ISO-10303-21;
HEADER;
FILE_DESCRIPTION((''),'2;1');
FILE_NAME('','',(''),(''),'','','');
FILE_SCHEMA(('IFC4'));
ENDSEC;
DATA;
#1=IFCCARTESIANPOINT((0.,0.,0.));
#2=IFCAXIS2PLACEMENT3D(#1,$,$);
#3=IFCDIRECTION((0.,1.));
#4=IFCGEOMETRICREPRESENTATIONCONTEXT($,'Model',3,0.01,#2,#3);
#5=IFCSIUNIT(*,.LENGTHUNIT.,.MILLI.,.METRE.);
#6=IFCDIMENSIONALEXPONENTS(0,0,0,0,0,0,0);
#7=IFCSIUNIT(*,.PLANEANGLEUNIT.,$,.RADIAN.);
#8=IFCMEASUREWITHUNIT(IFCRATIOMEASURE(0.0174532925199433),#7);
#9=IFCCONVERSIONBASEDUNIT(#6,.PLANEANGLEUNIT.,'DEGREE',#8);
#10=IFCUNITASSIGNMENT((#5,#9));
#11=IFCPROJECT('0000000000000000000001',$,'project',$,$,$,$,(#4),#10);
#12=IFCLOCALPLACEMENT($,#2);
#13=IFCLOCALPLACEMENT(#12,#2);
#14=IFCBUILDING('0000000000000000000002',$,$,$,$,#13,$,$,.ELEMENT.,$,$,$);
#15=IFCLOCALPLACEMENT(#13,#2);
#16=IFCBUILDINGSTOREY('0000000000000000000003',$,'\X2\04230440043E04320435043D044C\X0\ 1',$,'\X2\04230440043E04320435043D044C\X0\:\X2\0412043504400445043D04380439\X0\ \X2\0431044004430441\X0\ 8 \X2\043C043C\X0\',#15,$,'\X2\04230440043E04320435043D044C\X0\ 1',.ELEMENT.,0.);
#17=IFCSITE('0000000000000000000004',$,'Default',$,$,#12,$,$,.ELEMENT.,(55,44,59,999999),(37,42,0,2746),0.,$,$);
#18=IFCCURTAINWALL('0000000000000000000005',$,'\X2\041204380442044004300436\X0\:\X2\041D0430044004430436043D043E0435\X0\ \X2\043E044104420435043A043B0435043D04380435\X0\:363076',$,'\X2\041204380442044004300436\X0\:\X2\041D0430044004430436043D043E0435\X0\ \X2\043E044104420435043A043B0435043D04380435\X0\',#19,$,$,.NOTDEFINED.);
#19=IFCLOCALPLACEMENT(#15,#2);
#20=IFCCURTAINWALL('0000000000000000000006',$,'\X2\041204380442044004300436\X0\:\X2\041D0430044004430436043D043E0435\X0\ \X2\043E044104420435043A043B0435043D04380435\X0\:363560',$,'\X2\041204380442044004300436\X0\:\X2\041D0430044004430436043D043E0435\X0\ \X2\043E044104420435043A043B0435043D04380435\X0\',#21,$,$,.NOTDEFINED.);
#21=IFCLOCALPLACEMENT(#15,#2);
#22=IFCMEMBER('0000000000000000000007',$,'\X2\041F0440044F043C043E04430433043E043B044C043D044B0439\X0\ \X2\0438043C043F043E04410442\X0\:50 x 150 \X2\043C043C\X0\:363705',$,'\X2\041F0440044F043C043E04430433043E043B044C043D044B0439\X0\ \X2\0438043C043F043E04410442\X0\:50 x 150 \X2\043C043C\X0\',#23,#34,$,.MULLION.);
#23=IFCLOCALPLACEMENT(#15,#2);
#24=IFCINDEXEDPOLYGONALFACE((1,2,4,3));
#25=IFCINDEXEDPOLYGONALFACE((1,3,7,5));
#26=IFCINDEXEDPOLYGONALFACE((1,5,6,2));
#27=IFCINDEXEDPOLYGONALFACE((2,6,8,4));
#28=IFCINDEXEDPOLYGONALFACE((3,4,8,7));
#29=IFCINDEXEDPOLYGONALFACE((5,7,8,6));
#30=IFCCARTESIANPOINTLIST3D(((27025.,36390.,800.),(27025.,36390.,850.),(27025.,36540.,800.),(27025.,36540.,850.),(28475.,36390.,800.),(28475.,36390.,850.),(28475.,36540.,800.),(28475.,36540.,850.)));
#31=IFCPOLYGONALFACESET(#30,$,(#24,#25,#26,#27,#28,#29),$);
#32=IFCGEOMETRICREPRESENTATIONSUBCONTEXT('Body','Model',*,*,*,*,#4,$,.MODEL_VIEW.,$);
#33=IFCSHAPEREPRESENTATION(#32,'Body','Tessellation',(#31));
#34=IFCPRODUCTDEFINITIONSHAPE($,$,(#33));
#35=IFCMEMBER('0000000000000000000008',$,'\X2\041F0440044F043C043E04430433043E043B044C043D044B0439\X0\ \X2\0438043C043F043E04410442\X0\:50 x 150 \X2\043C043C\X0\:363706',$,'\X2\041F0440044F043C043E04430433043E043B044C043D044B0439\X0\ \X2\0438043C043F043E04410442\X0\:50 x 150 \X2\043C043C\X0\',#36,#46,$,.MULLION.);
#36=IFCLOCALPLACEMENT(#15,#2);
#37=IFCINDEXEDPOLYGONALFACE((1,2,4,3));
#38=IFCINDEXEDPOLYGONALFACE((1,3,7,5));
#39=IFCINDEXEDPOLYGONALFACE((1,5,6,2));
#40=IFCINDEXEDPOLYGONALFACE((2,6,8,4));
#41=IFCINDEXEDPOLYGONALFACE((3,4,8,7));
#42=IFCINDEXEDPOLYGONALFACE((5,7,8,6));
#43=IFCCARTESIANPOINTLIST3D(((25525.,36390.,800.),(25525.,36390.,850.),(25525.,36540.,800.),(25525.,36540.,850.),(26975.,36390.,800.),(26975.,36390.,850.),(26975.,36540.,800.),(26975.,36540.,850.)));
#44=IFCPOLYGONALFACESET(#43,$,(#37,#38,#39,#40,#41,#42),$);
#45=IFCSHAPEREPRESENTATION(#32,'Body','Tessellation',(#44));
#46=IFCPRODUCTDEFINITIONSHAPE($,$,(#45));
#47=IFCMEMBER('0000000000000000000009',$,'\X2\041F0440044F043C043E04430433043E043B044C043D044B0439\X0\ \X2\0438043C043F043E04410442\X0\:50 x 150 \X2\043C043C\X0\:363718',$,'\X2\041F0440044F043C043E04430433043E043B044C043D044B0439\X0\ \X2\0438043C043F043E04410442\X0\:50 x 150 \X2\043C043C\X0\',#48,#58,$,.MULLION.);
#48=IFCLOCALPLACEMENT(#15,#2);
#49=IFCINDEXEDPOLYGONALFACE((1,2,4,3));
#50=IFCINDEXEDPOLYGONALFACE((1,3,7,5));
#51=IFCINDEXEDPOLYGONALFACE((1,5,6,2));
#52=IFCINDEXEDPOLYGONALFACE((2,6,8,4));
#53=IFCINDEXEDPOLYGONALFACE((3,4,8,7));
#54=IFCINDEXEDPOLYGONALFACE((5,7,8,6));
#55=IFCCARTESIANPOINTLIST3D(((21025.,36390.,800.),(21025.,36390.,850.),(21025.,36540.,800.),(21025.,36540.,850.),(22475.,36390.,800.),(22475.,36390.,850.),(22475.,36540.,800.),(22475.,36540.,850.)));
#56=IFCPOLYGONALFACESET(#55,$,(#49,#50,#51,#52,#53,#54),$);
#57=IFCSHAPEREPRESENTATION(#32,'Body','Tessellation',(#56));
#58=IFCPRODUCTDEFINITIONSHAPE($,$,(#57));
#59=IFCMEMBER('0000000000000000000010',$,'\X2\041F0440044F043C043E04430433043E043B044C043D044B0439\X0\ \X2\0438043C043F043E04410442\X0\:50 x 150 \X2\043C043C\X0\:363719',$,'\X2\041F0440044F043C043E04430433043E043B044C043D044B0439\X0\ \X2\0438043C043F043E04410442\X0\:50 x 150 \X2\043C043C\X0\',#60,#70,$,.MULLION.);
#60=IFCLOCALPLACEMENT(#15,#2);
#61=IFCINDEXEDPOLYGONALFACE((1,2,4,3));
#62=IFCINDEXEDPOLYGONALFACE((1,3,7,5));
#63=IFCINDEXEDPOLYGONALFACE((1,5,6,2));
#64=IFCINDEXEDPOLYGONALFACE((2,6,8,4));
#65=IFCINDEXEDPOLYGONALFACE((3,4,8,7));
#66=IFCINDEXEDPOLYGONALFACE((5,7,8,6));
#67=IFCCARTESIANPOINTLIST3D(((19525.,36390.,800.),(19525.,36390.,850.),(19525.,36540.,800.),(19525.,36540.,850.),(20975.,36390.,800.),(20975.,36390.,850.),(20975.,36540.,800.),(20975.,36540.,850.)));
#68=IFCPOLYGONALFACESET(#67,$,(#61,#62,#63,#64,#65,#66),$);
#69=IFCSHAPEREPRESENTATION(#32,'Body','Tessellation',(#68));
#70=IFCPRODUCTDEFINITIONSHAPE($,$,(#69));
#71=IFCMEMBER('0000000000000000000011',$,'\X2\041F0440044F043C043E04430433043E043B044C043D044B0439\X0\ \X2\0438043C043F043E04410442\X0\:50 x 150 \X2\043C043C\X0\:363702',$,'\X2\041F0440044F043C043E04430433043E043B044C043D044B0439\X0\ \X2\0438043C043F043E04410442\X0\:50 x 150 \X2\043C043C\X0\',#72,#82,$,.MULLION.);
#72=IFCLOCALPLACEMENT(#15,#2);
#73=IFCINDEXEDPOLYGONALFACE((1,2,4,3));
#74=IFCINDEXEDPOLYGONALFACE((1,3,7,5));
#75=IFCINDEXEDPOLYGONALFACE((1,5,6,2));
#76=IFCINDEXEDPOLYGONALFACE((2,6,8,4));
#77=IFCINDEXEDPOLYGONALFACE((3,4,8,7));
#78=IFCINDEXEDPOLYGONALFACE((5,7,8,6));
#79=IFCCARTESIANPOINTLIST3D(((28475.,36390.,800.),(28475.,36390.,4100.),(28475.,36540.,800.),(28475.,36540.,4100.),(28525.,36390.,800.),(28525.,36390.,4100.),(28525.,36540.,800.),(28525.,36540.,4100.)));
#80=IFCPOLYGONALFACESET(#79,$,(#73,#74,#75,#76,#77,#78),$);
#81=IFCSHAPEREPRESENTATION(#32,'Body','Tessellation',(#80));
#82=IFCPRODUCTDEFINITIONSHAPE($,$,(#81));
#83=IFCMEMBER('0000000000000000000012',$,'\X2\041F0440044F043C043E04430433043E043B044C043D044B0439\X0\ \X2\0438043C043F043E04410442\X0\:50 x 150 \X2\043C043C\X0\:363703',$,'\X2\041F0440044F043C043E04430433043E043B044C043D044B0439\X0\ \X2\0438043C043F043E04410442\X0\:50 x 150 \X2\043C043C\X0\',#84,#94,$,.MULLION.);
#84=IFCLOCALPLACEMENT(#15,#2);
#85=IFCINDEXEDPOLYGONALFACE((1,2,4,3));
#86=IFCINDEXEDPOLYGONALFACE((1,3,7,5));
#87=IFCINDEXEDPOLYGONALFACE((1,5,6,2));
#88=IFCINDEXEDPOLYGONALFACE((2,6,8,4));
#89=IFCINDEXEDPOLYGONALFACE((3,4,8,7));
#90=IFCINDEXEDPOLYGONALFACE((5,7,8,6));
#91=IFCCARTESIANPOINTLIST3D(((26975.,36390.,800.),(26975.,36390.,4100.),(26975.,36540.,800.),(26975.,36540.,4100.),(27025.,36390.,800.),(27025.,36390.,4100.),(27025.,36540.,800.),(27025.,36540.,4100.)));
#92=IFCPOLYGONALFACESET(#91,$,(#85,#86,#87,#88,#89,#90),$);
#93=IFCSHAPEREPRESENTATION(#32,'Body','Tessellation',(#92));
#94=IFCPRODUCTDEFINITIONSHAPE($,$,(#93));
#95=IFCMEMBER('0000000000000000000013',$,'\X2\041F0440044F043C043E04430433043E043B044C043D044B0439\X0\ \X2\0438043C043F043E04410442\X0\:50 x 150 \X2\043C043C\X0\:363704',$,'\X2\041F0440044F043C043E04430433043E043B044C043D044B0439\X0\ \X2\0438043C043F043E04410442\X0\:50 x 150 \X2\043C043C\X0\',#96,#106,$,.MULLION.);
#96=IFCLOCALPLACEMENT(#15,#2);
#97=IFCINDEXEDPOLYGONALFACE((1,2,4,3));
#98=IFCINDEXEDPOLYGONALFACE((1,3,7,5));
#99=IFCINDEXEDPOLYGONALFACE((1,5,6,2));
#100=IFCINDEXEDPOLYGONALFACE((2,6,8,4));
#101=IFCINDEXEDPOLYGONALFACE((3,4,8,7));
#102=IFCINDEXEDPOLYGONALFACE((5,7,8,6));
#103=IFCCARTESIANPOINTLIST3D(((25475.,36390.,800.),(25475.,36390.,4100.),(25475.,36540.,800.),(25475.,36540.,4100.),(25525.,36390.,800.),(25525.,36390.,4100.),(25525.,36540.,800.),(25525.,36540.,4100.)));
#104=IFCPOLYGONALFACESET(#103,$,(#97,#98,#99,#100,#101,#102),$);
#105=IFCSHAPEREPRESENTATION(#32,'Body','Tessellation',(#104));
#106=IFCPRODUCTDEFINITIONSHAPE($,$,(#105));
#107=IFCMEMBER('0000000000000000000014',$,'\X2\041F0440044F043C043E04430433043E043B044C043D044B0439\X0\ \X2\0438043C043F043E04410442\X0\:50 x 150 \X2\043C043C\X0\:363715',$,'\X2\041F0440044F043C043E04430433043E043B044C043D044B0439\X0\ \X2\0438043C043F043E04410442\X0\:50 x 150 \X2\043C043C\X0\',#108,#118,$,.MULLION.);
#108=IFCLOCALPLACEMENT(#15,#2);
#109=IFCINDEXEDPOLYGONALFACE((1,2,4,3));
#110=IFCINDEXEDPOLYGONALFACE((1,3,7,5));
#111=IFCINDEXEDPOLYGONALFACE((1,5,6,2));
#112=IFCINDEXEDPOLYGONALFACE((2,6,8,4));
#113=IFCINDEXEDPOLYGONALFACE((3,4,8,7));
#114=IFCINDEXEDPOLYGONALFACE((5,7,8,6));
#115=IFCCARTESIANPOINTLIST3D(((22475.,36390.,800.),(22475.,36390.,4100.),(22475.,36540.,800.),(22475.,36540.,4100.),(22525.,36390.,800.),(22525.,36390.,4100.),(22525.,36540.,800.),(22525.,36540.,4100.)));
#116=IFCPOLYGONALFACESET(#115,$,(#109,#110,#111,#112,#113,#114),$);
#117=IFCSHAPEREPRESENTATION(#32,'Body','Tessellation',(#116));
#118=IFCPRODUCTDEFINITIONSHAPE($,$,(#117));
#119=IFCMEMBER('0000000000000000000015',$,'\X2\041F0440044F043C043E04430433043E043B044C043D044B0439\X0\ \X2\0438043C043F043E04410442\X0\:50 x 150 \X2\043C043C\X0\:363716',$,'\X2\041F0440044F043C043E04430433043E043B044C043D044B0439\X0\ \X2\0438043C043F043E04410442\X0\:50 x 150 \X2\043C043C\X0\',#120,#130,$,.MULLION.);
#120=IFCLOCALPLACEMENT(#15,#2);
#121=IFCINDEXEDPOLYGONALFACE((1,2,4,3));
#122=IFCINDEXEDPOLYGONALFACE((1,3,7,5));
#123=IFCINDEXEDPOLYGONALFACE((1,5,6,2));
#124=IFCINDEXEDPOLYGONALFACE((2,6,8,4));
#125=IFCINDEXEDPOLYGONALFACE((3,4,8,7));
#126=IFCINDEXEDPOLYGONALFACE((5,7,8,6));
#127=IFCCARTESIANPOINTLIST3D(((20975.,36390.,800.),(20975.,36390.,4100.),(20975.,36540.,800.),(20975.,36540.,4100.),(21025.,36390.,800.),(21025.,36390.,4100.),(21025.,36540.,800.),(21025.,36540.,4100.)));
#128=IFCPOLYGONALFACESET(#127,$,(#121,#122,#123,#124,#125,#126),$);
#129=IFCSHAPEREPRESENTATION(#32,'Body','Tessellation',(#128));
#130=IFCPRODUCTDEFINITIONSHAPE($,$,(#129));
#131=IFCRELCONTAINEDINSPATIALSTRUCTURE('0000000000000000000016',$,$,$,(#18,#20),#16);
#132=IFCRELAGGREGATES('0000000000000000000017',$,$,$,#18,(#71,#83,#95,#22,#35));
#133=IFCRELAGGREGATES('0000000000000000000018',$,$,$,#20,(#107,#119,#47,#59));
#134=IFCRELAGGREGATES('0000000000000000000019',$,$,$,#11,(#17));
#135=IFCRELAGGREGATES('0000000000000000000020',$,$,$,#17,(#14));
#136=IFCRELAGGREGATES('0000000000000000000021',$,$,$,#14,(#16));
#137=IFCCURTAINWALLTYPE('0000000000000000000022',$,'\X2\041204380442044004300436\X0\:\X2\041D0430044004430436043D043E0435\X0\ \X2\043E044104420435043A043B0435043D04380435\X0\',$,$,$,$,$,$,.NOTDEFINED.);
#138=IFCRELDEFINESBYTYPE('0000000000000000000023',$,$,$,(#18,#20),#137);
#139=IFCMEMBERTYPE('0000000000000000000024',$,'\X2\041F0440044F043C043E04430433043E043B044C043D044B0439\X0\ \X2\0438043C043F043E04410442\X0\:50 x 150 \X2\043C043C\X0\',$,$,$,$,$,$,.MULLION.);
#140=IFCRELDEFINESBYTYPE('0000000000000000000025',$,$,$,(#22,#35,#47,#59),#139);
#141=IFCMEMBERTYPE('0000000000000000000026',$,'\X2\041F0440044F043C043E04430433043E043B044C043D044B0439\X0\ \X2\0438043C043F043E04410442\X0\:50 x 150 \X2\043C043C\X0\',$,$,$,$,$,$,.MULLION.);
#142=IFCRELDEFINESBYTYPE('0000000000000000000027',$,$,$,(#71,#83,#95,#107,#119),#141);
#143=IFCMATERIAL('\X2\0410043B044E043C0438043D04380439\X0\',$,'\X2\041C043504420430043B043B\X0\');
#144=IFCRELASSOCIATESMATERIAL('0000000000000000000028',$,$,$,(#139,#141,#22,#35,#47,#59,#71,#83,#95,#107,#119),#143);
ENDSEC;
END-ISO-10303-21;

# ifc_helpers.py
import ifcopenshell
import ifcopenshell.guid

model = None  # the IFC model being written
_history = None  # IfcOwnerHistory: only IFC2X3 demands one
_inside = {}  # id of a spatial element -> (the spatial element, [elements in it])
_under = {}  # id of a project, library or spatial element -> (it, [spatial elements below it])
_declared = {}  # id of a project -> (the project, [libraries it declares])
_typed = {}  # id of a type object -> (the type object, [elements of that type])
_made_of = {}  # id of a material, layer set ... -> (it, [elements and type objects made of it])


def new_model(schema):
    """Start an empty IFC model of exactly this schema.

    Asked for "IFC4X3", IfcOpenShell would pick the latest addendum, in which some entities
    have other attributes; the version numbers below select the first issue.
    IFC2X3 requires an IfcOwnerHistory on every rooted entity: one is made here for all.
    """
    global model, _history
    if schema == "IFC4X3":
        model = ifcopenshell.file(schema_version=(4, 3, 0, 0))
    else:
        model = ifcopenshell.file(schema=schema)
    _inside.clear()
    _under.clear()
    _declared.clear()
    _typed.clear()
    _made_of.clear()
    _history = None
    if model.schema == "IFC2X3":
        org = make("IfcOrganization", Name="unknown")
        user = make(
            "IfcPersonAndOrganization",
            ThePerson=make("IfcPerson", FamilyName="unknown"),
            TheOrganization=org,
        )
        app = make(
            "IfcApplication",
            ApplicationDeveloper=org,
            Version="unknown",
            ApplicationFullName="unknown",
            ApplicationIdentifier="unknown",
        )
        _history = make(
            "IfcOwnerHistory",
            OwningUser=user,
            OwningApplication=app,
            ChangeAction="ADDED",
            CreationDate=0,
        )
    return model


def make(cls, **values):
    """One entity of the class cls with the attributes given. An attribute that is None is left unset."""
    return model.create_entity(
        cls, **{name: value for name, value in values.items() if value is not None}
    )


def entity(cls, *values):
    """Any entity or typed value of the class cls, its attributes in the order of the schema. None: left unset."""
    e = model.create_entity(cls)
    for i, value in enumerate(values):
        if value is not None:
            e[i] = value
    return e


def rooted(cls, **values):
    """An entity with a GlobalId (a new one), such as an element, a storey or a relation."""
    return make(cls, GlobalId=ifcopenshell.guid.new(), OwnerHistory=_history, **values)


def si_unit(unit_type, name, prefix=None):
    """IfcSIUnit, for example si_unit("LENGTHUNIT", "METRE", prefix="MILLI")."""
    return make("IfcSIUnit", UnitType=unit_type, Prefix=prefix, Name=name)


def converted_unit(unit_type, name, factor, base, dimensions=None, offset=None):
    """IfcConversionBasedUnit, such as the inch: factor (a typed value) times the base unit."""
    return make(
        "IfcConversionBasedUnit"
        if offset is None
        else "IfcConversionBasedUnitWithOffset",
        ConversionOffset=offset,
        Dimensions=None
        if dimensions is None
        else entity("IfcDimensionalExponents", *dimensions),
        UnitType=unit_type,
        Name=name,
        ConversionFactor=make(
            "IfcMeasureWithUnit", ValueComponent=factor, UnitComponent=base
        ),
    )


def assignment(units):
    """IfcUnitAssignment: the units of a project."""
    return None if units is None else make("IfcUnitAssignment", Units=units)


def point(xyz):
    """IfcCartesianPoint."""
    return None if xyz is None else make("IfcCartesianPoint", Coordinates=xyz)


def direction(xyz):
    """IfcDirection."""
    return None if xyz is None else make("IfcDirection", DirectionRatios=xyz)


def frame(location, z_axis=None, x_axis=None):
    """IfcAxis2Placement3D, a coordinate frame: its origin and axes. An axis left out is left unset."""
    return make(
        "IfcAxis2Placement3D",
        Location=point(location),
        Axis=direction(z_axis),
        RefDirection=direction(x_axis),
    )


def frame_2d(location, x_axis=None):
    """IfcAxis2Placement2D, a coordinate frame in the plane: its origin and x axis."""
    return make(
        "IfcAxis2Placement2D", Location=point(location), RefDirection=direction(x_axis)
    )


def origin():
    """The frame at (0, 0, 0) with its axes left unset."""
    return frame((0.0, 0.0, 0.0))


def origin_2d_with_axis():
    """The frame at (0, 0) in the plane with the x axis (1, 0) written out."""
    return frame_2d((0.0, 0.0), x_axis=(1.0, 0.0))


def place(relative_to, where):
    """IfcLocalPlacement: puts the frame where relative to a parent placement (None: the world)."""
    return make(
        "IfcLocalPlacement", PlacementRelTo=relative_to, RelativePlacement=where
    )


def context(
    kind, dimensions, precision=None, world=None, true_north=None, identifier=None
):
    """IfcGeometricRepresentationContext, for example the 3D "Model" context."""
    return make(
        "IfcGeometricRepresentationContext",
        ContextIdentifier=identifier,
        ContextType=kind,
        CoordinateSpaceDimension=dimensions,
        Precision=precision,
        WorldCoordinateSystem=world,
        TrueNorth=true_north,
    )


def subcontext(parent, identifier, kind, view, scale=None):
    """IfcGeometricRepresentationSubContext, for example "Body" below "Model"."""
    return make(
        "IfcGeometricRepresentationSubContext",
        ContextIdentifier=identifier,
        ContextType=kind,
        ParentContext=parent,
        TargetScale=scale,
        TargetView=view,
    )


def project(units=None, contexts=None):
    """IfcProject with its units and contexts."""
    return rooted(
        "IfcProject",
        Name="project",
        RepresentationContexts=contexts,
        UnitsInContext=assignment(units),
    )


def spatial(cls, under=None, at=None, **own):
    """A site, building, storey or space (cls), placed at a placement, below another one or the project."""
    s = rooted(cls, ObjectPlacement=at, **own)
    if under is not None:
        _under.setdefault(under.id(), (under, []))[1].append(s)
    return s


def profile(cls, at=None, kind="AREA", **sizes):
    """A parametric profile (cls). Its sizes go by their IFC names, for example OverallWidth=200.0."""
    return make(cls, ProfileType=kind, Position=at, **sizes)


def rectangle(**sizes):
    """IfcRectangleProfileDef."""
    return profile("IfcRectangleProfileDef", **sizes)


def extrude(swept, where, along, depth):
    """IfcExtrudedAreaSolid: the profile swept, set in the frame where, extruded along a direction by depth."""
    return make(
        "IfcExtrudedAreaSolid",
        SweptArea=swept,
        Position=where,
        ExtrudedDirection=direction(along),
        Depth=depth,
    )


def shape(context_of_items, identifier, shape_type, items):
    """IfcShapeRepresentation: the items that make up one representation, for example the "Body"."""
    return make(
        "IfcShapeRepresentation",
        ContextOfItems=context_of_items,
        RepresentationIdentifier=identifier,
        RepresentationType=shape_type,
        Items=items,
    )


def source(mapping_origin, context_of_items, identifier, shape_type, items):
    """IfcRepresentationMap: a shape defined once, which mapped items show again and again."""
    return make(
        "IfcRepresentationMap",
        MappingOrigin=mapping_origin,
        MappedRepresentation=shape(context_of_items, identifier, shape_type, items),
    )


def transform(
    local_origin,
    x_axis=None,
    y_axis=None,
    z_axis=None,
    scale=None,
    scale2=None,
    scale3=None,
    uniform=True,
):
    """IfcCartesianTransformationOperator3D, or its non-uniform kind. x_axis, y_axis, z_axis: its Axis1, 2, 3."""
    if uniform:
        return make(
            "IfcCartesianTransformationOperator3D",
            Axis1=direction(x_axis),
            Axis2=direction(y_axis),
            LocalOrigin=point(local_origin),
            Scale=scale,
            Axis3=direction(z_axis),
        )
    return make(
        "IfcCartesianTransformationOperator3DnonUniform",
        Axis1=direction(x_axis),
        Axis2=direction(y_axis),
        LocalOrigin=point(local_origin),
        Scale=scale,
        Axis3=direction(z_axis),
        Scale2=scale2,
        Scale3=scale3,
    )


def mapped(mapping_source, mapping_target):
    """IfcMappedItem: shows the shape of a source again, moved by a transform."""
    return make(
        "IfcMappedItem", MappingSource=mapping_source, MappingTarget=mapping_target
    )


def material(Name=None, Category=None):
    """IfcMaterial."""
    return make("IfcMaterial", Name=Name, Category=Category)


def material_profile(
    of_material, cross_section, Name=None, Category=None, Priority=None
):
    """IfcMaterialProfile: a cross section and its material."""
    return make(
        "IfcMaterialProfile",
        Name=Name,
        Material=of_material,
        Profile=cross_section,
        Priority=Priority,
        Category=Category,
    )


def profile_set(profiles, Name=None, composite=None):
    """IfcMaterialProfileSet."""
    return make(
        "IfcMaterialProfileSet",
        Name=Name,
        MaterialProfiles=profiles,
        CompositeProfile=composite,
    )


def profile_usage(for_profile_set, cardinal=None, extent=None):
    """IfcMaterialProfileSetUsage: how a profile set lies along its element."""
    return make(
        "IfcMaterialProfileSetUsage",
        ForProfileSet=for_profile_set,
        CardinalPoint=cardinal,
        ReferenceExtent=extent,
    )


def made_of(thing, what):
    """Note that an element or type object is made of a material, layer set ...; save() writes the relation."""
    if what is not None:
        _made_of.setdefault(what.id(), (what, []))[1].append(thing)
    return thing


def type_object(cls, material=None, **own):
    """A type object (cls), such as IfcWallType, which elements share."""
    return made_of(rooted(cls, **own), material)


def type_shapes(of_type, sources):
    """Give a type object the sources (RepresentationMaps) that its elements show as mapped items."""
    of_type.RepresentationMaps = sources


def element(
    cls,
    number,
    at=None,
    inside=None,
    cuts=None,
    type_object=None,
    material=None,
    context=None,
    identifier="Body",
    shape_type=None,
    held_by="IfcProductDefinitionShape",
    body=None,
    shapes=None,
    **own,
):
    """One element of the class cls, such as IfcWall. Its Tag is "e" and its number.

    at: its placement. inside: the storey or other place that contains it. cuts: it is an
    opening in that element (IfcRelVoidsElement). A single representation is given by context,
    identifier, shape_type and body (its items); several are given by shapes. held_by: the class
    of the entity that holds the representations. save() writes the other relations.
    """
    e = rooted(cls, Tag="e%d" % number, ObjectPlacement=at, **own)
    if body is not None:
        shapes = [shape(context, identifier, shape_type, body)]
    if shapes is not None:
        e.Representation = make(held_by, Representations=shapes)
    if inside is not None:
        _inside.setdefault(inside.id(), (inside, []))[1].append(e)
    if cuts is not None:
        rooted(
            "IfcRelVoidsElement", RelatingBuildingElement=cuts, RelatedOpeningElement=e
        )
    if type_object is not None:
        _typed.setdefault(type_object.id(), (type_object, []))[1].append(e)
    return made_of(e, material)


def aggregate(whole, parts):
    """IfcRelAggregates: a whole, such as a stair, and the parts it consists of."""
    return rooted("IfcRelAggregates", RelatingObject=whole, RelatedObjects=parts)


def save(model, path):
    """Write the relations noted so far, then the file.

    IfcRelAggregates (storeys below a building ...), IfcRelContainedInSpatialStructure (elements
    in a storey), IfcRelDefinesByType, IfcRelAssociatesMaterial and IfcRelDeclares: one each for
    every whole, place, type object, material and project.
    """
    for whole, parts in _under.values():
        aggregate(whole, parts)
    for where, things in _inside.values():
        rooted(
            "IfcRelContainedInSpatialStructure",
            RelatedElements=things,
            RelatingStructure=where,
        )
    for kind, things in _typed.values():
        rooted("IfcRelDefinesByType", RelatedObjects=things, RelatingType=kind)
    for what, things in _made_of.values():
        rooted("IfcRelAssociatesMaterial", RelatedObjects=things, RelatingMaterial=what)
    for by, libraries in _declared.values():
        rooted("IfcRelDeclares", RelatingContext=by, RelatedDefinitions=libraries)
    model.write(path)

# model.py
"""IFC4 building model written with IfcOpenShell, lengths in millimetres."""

from ifc_helpers import new_model, entity, si_unit, converted_unit, direction, frame, origin, origin_2d_with_axis, place, context, subcontext, project, spatial, rectangle, extrude, source, transform, mapped, material, material_profile, profile_set, profile_usage, type_object, type_shapes, element, aggregate, save


model = new_model("IFC4")

# Units and contexts
model_context = context("Model", 3, precision=0.01, world=origin(), true_north=direction((0.0, 1.0)))
body_context = subcontext(model_context, "Body", "Model", "MODEL_VIEW")
ifc_project = project(units=[si_unit("LENGTHUNIT", "METRE", prefix="MILLI"), converted_unit("PLANEANGLEUNIT", "DEGREE", entity("IfcRatioMeasure", 0.0174532925199433), si_unit("PLANEANGLEUNIT", "RADIAN"), dimensions=[0, 0, 0, 0, 0, 0, 0])], contexts=[model_context])

# Site, building, storey
site_placement = place(None, origin())
site = spatial("IfcSite", under=ifc_project, at=site_placement, Name="Default", CompositionType="ELEMENT", RefLatitude=(55, 44, 59, 999999), RefLongitude=(37, 42, 0, 2746), RefElevation=0.0)
building_placement = place(site_placement, origin())
building = spatial("IfcBuilding", under=site, at=building_placement, CompositionType="ELEMENT")
storey_placement = place(building_placement, origin())
storey = spatial("IfcBuildingStorey", under=building, at=storey_placement, Name="Уровень 1", ObjectType="Уровень:Верхний брус 8 мм", LongName="Уровень 1", CompositionType="ELEMENT", Elevation=0.0)

# Curtain wall
curtain_wall_type = type_object("IfcCurtainWallType", Name="Витраж:Наружное остекление", PredefinedType="NOTDEFINED")
curtain_wall_1_placement = place(storey_placement, origin())
curtain_wall_1 = element("IfcCurtainWall", 1, at=curtain_wall_1_placement, inside=storey, type_object=curtain_wall_type, Name="Витраж:Наружное остекление:363076", ObjectType="Витраж:Наружное остекление", PredefinedType="NOTDEFINED")
ifc_material_1 = material(Name="Алюминий", Category="Металл")
ifc_material_profile = material_profile(ifc_material_1, rectangle(XDim=150.0, YDim=50.0, at=origin_2d_with_axis()), Name="50 x 150 мм")
ifc_profile_set = profile_set([ifc_material_profile], Name="50 x 150 мм")

# Curtain wall
curtain_wall_2_placement = place(storey_placement, origin())
curtain_wall_2 = element("IfcCurtainWall", 2, at=curtain_wall_2_placement, inside=storey, type_object=curtain_wall_type, Name="Витраж:Наружное остекление:363560", ObjectType="Витраж:Наружное остекление", PredefinedType="NOTDEFINED")

# Members
ifc_profile_usage_1 = profile_usage(ifc_profile_set)
member_type_1 = type_object("IfcMemberType", Name="Прямоугольный импост:50 x 150 мм", PredefinedType="MULLION", material=ifc_profile_set)
shared_shape_1 = source(origin(), body_context, "Body", "SweptSolid", [
    extrude(rectangle(XDim=150.0, YDim=50.0, at=origin_2d_with_axis()), frame((-25.0, 0.0, -1450.0), z_axis=(0.0, 0.0, 1.0), x_axis=(0.0, -1.0, 0.0)), (0.0, 0.0, 1.0), 1450.0),
])
type_shapes(member_type_1, [shared_shape_1])
member_1_placement = place(storey_placement, frame((28475.0, 36465.0, 800.0), z_axis=(1.0, 0.0, 0.0), x_axis=(0.0, 0.0, -1.0)))
member_1 = element("IfcMember", 3, at=member_1_placement, type_object=member_type_1, material=ifc_profile_usage_1, Name="Прямоугольный импост:50 x 150 мм:363705", ObjectType="Прямоугольный импост:50 x 150 мм", PredefinedType="MULLION", context=body_context, shape_type="MappedRepresentation", body=[
    mapped(shared_shape_1, transform((0.0, 0.0, 0.0), scale=1.0)),
])
ifc_profile_usage_2 = profile_usage(ifc_profile_set)
member_2_placement = place(storey_placement, frame((26975.0, 36465.0, 800.0), z_axis=(1.0, 0.0, 0.0), x_axis=(0.0, 0.0, -1.0)))
member_2 = element("IfcMember", 4, at=member_2_placement, type_object=member_type_1, material=ifc_profile_usage_2, Name="Прямоугольный импост:50 x 150 мм:363706", ObjectType="Прямоугольный импост:50 x 150 мм", PredefinedType="MULLION", context=body_context, shape_type="MappedRepresentation", body=[
    mapped(shared_shape_1, transform((0.0, 0.0, 0.0), scale=1.0)),
])
ifc_profile_usage_3 = profile_usage(ifc_profile_set)
member_3_placement = place(storey_placement, frame((22475.0, 36465.0, 800.0), z_axis=(1.0, 0.0, 0.0), x_axis=(0.0, 0.0, -1.0)))
member_3 = element("IfcMember", 5, at=member_3_placement, type_object=member_type_1, material=ifc_profile_usage_3, Name="Прямоугольный импост:50 x 150 мм:363718", ObjectType="Прямоугольный импост:50 x 150 мм", PredefinedType="MULLION", context=body_context, shape_type="MappedRepresentation", body=[
    mapped(shared_shape_1, transform((0.0, 0.0, 0.0), scale=1.0)),
])
ifc_profile_usage_4 = profile_usage(ifc_profile_set)
member_4_placement = place(storey_placement, frame((20975.0, 36465.0, 800.0), z_axis=(1.0, 0.0, 0.0), x_axis=(0.0, 0.0, -1.0)))
member_4 = element("IfcMember", 6, at=member_4_placement, type_object=member_type_1, material=ifc_profile_usage_4, Name="Прямоугольный импост:50 x 150 мм:363719", ObjectType="Прямоугольный импост:50 x 150 мм", PredefinedType="MULLION", context=body_context, shape_type="MappedRepresentation", body=[
    mapped(shared_shape_1, transform((0.0, 0.0, 0.0), scale=1.0)),
])
ifc_profile_usage_5 = profile_usage(ifc_profile_set)
member_type_2 = type_object("IfcMemberType", Name="Прямоугольный импост:50 x 150 мм", PredefinedType="MULLION", material=ifc_profile_set)
shared_shape_2 = source(origin(), body_context, "Body", "SweptSolid", [
    extrude(rectangle(XDim=150.0, YDim=50.0, at=origin_2d_with_axis()), frame((0.0, 0.0, -3300.0), z_axis=(0.0, 0.0, 1.0), x_axis=(0.0, -1.0, 0.0)), (0.0, 0.0, 1.0), 3300.0),
])
type_shapes(member_type_2, [shared_shape_2])
member_5_placement = place(storey_placement, frame((28500.0, 36465.0, 800.0), z_axis=(0.0, 0.0, -1.0), x_axis=(-1.0, 0.0, 0.0)))
member_5 = element("IfcMember", 7, at=member_5_placement, type_object=member_type_2, material=ifc_profile_usage_5, Name="Прямоугольный импост:50 x 150 мм:363702", ObjectType="Прямоугольный импост:50 x 150 мм", PredefinedType="MULLION", context=body_context, shape_type="MappedRepresentation", body=[
    mapped(shared_shape_2, transform((0.0, 0.0, 0.0), scale=1.0)),
])
ifc_profile_usage_6 = profile_usage(ifc_profile_set)
member_6_placement = place(storey_placement, frame((27000.0, 36465.0, 800.0), z_axis=(0.0, 0.0, -1.0), x_axis=(-1.0, 0.0, 0.0)))
member_6 = element("IfcMember", 8, at=member_6_placement, type_object=member_type_2, material=ifc_profile_usage_6, Name="Прямоугольный импост:50 x 150 мм:363703", ObjectType="Прямоугольный импост:50 x 150 мм", PredefinedType="MULLION", context=body_context, shape_type="MappedRepresentation", body=[
    mapped(shared_shape_2, transform((0.0, 0.0, 0.0), scale=1.0)),
])
ifc_profile_usage_7 = profile_usage(ifc_profile_set)
member_7_placement = place(storey_placement, frame((25500.0, 36465.0, 800.0), z_axis=(0.0, 0.0, -1.0), x_axis=(-1.0, 0.0, 0.0)))
member_7 = element("IfcMember", 9, at=member_7_placement, type_object=member_type_2, material=ifc_profile_usage_7, Name="Прямоугольный импост:50 x 150 мм:363704", ObjectType="Прямоугольный импост:50 x 150 мм", PredefinedType="MULLION", context=body_context, shape_type="MappedRepresentation", body=[
    mapped(shared_shape_2, transform((0.0, 0.0, 0.0), scale=1.0)),
])
aggregate(curtain_wall_1, [member_5, member_6, member_7, member_1, member_2])
ifc_profile_usage_8 = profile_usage(ifc_profile_set)
member_8_placement = place(storey_placement, frame((22500.0, 36465.0, 800.0), z_axis=(0.0, 0.0, -1.0), x_axis=(-1.0, 0.0, 0.0)))
member_8 = element("IfcMember", 10, at=member_8_placement, type_object=member_type_2, material=ifc_profile_usage_8, Name="Прямоугольный импост:50 x 150 мм:363715", ObjectType="Прямоугольный импост:50 x 150 мм", PredefinedType="MULLION", context=body_context, shape_type="MappedRepresentation", body=[
    mapped(shared_shape_2, transform((0.0, 0.0, 0.0), scale=1.0)),
])
ifc_profile_usage_9 = profile_usage(ifc_profile_set)
member_9_placement = place(storey_placement, frame((21000.0, 36465.0, 800.0), z_axis=(0.0, 0.0, -1.0), x_axis=(-1.0, 0.0, 0.0)))
member_9 = element("IfcMember", 11, at=member_9_placement, type_object=member_type_2, material=ifc_profile_usage_9, Name="Прямоугольный импост:50 x 150 мм:363716", ObjectType="Прямоугольный импост:50 x 150 мм", PredefinedType="MULLION", context=body_context, shape_type="MappedRepresentation", body=[
    mapped(shared_shape_2, transform((0.0, 0.0, 0.0), scale=1.0)),
])

aggregate(curtain_wall_2, [member_8, member_9, member_3, member_4])

save(model, "model.ifc")
